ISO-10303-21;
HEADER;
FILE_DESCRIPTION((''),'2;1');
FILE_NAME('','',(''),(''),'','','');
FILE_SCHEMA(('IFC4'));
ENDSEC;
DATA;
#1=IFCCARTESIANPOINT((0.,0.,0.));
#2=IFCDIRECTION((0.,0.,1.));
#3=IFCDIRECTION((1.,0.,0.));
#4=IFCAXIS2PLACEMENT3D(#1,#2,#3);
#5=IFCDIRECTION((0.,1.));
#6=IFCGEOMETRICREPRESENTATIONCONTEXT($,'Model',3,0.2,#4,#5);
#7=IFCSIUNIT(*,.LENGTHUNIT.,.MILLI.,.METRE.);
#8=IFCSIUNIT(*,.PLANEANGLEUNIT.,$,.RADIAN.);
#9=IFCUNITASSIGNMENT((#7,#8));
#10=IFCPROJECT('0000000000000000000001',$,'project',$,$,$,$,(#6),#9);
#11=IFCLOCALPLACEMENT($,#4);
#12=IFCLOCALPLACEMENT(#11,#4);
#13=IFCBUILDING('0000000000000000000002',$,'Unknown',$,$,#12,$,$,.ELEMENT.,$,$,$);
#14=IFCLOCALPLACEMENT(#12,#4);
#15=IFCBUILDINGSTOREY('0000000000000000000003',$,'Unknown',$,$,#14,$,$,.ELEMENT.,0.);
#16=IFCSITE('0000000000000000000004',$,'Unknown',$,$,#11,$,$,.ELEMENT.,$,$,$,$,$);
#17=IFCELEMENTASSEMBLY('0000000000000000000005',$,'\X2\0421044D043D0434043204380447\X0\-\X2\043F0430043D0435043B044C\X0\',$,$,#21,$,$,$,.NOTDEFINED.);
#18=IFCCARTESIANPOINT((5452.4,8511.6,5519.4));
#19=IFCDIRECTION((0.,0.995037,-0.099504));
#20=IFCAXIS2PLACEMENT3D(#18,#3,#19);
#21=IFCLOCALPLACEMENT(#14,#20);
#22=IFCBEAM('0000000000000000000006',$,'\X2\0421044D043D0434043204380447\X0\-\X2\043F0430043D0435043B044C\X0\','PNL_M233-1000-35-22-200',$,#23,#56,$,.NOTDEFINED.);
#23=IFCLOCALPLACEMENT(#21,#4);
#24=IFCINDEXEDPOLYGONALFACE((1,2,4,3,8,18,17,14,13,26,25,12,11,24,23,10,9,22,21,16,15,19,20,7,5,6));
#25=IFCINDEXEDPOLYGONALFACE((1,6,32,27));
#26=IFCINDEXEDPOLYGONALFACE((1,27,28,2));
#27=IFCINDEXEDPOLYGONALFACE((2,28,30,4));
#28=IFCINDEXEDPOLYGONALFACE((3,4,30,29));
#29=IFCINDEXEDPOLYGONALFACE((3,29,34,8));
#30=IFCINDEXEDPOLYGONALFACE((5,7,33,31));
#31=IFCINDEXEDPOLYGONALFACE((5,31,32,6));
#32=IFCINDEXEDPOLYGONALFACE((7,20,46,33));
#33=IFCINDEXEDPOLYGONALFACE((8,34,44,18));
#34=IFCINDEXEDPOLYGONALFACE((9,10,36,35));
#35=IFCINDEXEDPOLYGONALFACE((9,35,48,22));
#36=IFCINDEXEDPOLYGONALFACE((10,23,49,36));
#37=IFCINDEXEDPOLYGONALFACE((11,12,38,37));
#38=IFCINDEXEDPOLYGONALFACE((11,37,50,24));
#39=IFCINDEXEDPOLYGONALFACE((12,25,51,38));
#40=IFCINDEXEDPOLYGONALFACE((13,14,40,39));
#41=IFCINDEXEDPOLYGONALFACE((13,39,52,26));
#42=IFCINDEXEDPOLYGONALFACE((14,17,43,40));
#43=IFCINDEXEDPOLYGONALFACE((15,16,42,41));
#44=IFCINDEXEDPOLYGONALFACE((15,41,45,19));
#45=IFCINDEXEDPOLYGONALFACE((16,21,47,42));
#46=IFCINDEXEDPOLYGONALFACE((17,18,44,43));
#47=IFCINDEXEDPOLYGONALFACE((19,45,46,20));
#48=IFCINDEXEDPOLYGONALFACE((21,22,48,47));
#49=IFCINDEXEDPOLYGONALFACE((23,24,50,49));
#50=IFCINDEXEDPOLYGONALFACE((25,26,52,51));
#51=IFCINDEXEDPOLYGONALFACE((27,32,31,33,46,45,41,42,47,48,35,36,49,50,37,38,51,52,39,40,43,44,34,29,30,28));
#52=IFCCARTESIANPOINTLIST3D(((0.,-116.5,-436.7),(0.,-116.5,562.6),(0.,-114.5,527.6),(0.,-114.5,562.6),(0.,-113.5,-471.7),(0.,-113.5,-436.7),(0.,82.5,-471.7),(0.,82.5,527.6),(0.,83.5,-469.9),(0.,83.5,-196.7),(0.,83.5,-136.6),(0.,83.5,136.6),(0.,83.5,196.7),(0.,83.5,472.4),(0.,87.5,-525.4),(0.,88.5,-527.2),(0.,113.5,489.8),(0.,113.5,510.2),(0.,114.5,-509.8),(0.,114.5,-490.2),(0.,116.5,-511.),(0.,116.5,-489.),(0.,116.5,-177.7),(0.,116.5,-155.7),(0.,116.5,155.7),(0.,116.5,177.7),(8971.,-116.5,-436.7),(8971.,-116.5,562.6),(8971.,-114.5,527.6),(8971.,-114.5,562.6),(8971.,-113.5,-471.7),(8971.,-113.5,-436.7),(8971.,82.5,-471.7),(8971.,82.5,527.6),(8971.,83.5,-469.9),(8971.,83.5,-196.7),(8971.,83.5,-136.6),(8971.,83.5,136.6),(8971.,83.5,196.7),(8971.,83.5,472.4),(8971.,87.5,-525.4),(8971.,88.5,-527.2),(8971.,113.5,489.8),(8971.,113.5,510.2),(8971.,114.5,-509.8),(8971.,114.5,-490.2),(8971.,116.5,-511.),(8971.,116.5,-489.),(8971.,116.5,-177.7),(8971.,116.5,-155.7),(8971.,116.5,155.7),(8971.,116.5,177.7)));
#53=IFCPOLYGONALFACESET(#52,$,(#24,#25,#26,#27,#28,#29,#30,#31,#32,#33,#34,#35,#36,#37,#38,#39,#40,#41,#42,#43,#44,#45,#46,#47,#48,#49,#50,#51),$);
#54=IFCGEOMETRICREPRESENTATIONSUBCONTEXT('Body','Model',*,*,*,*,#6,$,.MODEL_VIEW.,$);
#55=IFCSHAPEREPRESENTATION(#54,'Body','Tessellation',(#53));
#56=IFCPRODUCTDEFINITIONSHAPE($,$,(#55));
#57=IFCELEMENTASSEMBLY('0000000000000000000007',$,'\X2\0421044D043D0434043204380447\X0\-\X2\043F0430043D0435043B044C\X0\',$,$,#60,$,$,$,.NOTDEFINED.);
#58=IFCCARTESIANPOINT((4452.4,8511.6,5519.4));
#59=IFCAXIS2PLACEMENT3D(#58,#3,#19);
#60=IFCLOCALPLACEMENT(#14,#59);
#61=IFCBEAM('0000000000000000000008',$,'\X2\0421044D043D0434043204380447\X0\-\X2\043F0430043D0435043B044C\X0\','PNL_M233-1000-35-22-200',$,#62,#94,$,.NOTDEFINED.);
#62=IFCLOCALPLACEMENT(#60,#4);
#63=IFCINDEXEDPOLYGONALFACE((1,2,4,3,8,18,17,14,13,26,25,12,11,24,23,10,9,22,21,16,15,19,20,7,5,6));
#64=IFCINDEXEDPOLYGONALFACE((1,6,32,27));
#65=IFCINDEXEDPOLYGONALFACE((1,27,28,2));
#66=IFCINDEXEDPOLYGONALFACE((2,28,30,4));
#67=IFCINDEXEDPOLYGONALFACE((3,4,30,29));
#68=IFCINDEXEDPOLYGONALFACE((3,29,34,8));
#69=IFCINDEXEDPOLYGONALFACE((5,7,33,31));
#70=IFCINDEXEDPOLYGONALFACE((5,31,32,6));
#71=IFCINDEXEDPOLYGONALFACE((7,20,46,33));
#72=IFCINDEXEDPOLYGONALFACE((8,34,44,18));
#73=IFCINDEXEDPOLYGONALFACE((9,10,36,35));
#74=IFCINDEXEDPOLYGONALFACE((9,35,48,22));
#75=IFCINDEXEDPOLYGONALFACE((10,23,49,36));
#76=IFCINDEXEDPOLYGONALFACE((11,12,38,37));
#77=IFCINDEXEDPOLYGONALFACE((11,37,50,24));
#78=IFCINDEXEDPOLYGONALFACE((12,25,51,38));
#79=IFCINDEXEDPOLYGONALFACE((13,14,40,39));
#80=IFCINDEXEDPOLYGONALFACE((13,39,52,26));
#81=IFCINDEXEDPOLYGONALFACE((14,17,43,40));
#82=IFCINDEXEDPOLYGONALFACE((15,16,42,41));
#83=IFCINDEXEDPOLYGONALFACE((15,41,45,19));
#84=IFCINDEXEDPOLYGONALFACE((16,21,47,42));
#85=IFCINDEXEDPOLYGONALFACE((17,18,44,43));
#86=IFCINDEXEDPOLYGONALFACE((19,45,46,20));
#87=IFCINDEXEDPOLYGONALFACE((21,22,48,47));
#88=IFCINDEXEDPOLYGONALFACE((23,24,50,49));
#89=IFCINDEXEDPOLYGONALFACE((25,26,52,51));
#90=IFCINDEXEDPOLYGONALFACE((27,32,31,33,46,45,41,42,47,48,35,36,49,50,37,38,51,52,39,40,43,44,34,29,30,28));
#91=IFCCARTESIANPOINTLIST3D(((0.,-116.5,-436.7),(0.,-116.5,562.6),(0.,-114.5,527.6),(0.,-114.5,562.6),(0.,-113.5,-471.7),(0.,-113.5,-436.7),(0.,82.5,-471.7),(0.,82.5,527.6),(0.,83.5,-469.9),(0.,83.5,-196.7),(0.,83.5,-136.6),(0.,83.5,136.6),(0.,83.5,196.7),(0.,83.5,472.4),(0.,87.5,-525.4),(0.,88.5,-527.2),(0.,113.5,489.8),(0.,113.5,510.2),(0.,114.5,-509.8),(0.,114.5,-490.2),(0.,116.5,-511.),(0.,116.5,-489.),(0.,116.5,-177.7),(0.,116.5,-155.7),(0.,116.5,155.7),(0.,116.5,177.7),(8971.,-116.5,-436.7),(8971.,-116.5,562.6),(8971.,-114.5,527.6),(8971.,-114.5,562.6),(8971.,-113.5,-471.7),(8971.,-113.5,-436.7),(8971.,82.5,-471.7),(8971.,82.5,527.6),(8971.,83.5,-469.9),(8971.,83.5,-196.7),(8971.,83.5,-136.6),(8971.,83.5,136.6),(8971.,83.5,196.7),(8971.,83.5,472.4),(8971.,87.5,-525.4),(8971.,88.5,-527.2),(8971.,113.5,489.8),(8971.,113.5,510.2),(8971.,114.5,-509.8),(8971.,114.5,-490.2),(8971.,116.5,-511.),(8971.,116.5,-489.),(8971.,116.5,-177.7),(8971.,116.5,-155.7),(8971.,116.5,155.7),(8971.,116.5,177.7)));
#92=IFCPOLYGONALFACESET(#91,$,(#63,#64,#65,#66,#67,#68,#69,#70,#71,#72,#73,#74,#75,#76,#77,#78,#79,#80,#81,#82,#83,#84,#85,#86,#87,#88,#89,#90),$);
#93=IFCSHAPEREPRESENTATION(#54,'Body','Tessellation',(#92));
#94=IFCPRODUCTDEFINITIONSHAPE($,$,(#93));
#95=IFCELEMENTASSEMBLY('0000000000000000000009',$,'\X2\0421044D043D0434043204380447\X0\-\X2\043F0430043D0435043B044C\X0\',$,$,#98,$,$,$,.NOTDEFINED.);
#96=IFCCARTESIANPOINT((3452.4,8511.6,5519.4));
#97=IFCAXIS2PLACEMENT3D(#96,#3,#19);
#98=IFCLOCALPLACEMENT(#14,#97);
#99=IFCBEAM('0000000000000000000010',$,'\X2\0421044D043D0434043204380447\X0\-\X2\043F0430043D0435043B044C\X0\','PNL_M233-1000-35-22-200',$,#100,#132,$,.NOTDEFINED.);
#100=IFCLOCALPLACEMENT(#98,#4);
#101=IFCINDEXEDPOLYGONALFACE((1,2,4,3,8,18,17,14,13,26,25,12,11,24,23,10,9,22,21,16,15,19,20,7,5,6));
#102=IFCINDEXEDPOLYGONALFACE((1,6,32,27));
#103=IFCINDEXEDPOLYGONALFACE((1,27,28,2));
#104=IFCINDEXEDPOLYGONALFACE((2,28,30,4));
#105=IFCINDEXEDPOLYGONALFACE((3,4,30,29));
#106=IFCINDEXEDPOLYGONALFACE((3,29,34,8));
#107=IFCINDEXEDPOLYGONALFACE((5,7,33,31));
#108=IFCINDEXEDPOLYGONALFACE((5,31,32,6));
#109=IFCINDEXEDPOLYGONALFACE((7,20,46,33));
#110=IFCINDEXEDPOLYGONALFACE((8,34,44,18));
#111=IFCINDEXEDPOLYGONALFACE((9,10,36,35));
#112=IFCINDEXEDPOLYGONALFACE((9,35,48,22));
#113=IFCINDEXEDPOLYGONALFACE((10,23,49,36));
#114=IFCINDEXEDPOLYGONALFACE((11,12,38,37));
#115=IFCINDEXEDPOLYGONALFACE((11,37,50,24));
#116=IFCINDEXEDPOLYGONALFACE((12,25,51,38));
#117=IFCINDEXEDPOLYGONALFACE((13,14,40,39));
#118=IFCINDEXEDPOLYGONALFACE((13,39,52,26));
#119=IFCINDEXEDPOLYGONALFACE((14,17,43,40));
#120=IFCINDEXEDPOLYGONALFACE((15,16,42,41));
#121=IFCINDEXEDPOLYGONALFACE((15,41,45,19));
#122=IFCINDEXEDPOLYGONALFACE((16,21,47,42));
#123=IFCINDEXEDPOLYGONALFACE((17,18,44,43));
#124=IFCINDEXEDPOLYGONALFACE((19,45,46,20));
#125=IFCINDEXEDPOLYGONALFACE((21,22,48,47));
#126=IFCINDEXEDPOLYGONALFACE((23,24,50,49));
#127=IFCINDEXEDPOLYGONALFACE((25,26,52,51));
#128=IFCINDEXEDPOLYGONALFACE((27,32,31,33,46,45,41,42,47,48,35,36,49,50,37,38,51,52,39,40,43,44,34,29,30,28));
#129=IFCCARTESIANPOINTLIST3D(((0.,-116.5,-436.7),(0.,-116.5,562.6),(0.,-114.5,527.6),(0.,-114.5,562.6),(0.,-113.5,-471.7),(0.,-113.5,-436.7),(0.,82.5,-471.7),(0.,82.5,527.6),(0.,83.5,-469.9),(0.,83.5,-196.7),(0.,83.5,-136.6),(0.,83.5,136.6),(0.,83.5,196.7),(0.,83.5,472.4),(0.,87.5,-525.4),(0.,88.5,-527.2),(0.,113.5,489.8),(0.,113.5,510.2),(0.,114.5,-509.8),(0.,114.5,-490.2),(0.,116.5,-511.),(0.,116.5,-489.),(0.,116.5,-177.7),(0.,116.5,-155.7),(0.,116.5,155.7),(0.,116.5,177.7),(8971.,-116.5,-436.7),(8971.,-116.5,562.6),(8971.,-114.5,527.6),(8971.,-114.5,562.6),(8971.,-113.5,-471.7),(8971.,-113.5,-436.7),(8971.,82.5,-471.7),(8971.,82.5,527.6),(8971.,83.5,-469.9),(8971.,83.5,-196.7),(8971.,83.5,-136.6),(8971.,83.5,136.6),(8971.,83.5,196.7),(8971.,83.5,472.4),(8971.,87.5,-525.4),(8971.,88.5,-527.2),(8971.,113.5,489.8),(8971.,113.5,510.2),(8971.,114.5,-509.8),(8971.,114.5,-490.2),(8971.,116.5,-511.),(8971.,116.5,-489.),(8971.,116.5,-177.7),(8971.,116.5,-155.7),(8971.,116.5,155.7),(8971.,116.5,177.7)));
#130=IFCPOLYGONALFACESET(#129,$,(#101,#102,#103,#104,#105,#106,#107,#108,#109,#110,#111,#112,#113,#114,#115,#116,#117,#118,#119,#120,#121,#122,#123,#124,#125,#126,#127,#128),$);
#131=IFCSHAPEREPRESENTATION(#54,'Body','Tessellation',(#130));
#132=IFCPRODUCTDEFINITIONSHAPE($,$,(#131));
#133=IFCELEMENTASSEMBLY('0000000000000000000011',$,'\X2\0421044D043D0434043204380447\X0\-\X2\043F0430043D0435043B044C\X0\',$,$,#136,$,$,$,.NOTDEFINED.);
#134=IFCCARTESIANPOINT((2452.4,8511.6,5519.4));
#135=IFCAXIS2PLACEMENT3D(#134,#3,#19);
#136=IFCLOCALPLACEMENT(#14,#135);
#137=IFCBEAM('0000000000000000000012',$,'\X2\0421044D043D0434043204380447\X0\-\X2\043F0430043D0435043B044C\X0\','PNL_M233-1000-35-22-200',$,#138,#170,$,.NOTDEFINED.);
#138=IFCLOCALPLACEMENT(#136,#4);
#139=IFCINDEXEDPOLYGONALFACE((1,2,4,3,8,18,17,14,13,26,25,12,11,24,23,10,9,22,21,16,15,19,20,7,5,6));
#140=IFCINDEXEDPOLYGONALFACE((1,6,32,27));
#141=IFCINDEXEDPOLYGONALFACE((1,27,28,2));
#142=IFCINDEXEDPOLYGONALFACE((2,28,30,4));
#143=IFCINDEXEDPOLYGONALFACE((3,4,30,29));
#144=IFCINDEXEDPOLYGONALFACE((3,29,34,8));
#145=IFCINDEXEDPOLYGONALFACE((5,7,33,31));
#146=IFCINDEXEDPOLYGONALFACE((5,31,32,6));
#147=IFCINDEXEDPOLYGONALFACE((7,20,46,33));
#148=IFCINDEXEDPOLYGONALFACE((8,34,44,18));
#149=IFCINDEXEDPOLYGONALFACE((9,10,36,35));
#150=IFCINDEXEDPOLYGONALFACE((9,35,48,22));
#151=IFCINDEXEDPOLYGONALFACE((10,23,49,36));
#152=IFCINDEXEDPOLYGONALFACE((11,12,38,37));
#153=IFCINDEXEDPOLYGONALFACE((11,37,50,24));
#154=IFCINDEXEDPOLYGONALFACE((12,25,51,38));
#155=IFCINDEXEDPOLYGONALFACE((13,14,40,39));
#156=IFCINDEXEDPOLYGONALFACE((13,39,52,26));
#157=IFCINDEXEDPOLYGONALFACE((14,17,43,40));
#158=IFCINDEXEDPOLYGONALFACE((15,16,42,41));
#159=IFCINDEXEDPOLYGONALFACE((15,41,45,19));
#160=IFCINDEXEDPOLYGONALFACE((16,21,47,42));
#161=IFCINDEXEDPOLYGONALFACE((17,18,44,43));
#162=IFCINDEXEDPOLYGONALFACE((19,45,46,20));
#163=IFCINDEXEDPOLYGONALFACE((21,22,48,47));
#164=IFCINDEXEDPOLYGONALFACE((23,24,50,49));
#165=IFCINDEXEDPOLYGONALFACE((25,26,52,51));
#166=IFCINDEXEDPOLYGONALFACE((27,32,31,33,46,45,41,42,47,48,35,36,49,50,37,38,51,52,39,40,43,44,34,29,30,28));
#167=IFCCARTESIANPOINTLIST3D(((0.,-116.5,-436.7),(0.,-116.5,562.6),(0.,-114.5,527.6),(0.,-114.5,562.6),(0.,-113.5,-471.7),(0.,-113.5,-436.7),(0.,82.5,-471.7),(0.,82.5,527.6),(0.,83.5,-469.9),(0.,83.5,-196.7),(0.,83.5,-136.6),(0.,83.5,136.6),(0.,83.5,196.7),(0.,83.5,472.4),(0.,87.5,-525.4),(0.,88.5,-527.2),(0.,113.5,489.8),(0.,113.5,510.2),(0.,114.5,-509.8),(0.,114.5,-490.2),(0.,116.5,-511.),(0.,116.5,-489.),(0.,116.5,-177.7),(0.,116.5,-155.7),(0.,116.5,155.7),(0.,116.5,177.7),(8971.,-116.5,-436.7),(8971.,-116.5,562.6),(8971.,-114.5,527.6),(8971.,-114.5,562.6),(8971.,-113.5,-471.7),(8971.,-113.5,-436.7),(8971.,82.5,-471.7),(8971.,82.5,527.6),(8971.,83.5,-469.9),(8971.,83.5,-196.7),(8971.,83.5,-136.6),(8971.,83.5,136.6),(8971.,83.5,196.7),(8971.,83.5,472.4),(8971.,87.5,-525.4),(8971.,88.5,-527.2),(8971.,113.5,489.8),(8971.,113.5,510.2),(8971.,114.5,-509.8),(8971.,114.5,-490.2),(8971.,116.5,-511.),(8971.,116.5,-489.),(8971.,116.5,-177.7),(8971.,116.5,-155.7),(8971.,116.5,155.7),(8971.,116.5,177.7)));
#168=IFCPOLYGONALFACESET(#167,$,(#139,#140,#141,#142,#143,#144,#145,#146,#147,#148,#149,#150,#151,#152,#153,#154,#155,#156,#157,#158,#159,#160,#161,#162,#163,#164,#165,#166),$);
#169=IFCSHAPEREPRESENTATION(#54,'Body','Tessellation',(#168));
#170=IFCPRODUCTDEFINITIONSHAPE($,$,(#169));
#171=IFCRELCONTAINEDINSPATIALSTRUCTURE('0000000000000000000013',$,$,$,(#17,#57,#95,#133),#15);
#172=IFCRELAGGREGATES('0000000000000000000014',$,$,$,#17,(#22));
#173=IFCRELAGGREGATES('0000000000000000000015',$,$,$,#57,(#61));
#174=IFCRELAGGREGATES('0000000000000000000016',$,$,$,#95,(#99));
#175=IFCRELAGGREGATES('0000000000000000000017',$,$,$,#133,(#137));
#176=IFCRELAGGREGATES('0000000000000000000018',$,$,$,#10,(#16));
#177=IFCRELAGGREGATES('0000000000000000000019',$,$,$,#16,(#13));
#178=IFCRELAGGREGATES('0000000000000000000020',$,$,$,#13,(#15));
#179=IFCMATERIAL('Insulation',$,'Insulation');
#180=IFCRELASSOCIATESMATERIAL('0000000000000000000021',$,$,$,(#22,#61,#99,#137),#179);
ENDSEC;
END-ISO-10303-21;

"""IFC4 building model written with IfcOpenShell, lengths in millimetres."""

from ifc_helpers import new_model, si_unit, direction, frame, origin_with_axes, place, context, subcontext, project, spatial, line, indexed_curve, outline, extrude, material, element, aggregate, save


model = new_model("IFC4")

# Units and contexts
model_context = context("Model", 3, precision=0.2, world=origin_with_axes(), true_north=direction((0.0, 1.0)))
body_context = subcontext(model_context, "Body", "Model", "MODEL_VIEW")
ifc_project = project(units=[si_unit("LENGTHUNIT", "METRE", prefix="MILLI"), si_unit("PLANEANGLEUNIT", "RADIAN")], contexts=[model_context])

# Site, building, storey
site_placement = place(None, origin_with_axes())
site = spatial("IfcSite", under=ifc_project, at=site_placement, Name="Unknown", CompositionType="ELEMENT")
building_placement = place(site_placement, origin_with_axes())
building = spatial("IfcBuilding", under=site, at=building_placement, Name="Unknown", CompositionType="ELEMENT")
storey_placement = place(building_placement, origin_with_axes())
storey = spatial("IfcBuildingStorey", under=building, at=storey_placement, Name="Unknown", CompositionType="ELEMENT", Elevation=0.0)

# Element assemblies, beams
assembly_1_placement = place(storey_placement, frame((5452.4, 8511.6, 5519.4), z_axis=(1.0, 0.0, 0.0), x_axis=(0.0, 0.995037, -0.099504)))
assembly_1 = element("IfcElementAssembly", 1, at=assembly_1_placement, inside=storey, Name="Сэндвич-панель", PredefinedType="NOTDEFINED")
ifc_material_1 = material(Name="Insulation", Category="Insulation")
beam_1_placement = place(assembly_1_placement, origin_with_axes())
beam_1 = element("IfcBeam", 2, at=beam_1_placement, material=ifc_material_1, Name="Сэндвич-панель", Description="PNL_M233-1000-35-22-200", PredefinedType="NOTDEFINED", context=body_context, shape_type="SolidModel", body=[
    extrude(outline(indexed_curve([(-509.8, 114.5), (-490.2, 114.5), (-471.7, 82.5), (-471.7, -113.5), (-436.7, -113.5), (-436.7, -116.5), (562.6, -116.5), (562.6, -114.5), (527.6, -114.5), (527.6, 82.5), (510.2, 113.5), (489.8, 113.5), (472.4, 83.5), (196.7, 83.5), (177.7, 116.5), (155.7, 116.5), (136.6, 83.5), (-136.6, 83.5), (-155.7, 116.5), (-177.7, 116.5), (-196.7, 83.5), (-469.9, 83.5), (-489.0, 116.5), (-511.0, 116.5), (-527.2, 88.5), (-525.4, 87.5)], segments=[line(1, 2, 3, 4, 5, 6, 7, 8, 9, 10, 11, 12, 13, 14, 15, 16, 17, 18, 19, 20, 21, 22, 23, 24, 25, 26, 1)])), frame((0.0, 0.0, 0.0), z_axis=(-1.0, 0.0, 0.0), x_axis=(0.0, 0.0, 1.0)), (0.0, 0.0, -1.0), 8971.0),
])
aggregate(assembly_1, [beam_1])
assembly_2_placement = place(storey_placement, frame((4452.4, 8511.6, 5519.4), z_axis=(1.0, 0.0, 0.0), x_axis=(0.0, 0.995037, -0.099504)))
assembly_2 = element("IfcElementAssembly", 3, at=assembly_2_placement, inside=storey, Name="Сэндвич-панель", PredefinedType="NOTDEFINED")
beam_2_placement = place(assembly_2_placement, origin_with_axes())
beam_2 = element("IfcBeam", 4, at=beam_2_placement, material=ifc_material_1, Name="Сэндвич-панель", Description="PNL_M233-1000-35-22-200", PredefinedType="NOTDEFINED", context=body_context, shape_type="SolidModel", body=[
    extrude(outline(indexed_curve([(-509.8, 114.5), (-490.2, 114.5), (-471.7, 82.5), (-471.7, -113.5), (-436.7, -113.5), (-436.7, -116.5), (562.6, -116.5), (562.6, -114.5), (527.6, -114.5), (527.6, 82.5), (510.2, 113.5), (489.8, 113.5), (472.4, 83.5), (196.7, 83.5), (177.7, 116.5), (155.7, 116.5), (136.6, 83.5), (-136.6, 83.5), (-155.7, 116.5), (-177.7, 116.5), (-196.7, 83.5), (-469.9, 83.5), (-489.0, 116.5), (-511.0, 116.5), (-527.2, 88.5), (-525.4, 87.5)], segments=[line(1, 2, 3, 4, 5, 6, 7, 8, 9, 10, 11, 12, 13, 14, 15, 16, 17, 18, 19, 20, 21, 22, 23, 24, 25, 26, 1)])), frame((0.0, 0.0, 0.0), z_axis=(-1.0, 0.0, 0.0), x_axis=(0.0, 0.0, 1.0)), (0.0, 0.0, -1.0), 8971.0),
])
aggregate(assembly_2, [beam_2])
assembly_3_placement = place(storey_placement, frame((3452.4, 8511.6, 5519.4), z_axis=(1.0, 0.0, 0.0), x_axis=(0.0, 0.995037, -0.099504)))
assembly_3 = element("IfcElementAssembly", 5, at=assembly_3_placement, inside=storey, Name="Сэндвич-панель", PredefinedType="NOTDEFINED")
beam_3_placement = place(assembly_3_placement, origin_with_axes())
beam_3 = element("IfcBeam", 6, at=beam_3_placement, material=ifc_material_1, Name="Сэндвич-панель", Description="PNL_M233-1000-35-22-200", PredefinedType="NOTDEFINED", context=body_context, shape_type="SolidModel", body=[
    extrude(outline(indexed_curve([(-509.8, 114.5), (-490.2, 114.5), (-471.7, 82.5), (-471.7, -113.5), (-436.7, -113.5), (-436.7, -116.5), (562.6, -116.5), (562.6, -114.5), (527.6, -114.5), (527.6, 82.5), (510.2, 113.5), (489.8, 113.5), (472.4, 83.5), (196.7, 83.5), (177.7, 116.5), (155.7, 116.5), (136.6, 83.5), (-136.6, 83.5), (-155.7, 116.5), (-177.7, 116.5), (-196.7, 83.5), (-469.9, 83.5), (-489.0, 116.5), (-511.0, 116.5), (-527.2, 88.5), (-525.4, 87.5)], segments=[line(1, 2, 3, 4, 5, 6, 7, 8, 9, 10, 11, 12, 13, 14, 15, 16, 17, 18, 19, 20, 21, 22, 23, 24, 25, 26, 1)])), frame((0.0, 0.0, 0.0), z_axis=(-1.0, 0.0, 0.0), x_axis=(0.0, 0.0, 1.0)), (0.0, 0.0, -1.0), 8971.0),
])
aggregate(assembly_3, [beam_3])
assembly_4_placement = place(storey_placement, frame((2452.4, 8511.6, 5519.4), z_axis=(1.0, 0.0, 0.0), x_axis=(0.0, 0.995037, -0.099504)))
assembly_4 = element("IfcElementAssembly", 7, at=assembly_4_placement, inside=storey, Name="Сэндвич-панель", PredefinedType="NOTDEFINED")
beam_4_placement = place(assembly_4_placement, origin_with_axes())
beam_4 = element("IfcBeam", 8, at=beam_4_placement, material=ifc_material_1, Name="Сэндвич-панель", Description="PNL_M233-1000-35-22-200", PredefinedType="NOTDEFINED", context=body_context, shape_type="SolidModel", body=[
    extrude(outline(indexed_curve([(-509.8, 114.5), (-490.2, 114.5), (-471.7, 82.5), (-471.7, -113.5), (-436.7, -113.5), (-436.7, -116.5), (562.6, -116.5), (562.6, -114.5), (527.6, -114.5), (527.6, 82.5), (510.2, 113.5), (489.8, 113.5), (472.4, 83.5), (196.7, 83.5), (177.7, 116.5), (155.7, 116.5), (136.6, 83.5), (-136.6, 83.5), (-155.7, 116.5), (-177.7, 116.5), (-196.7, 83.5), (-469.9, 83.5), (-489.0, 116.5), (-511.0, 116.5), (-527.2, 88.5), (-525.4, 87.5)], segments=[line(1, 2, 3, 4, 5, 6, 7, 8, 9, 10, 11, 12, 13, 14, 15, 16, 17, 18, 19, 20, 21, 22, 23, 24, 25, 26, 1)])), frame((0.0, 0.0, 0.0), z_axis=(-1.0, 0.0, 0.0), x_axis=(0.0, 0.0, 1.0)), (0.0, 0.0, -1.0), 8971.0),
])
aggregate(assembly_4, [beam_4])

save(model, "model.ifc")
